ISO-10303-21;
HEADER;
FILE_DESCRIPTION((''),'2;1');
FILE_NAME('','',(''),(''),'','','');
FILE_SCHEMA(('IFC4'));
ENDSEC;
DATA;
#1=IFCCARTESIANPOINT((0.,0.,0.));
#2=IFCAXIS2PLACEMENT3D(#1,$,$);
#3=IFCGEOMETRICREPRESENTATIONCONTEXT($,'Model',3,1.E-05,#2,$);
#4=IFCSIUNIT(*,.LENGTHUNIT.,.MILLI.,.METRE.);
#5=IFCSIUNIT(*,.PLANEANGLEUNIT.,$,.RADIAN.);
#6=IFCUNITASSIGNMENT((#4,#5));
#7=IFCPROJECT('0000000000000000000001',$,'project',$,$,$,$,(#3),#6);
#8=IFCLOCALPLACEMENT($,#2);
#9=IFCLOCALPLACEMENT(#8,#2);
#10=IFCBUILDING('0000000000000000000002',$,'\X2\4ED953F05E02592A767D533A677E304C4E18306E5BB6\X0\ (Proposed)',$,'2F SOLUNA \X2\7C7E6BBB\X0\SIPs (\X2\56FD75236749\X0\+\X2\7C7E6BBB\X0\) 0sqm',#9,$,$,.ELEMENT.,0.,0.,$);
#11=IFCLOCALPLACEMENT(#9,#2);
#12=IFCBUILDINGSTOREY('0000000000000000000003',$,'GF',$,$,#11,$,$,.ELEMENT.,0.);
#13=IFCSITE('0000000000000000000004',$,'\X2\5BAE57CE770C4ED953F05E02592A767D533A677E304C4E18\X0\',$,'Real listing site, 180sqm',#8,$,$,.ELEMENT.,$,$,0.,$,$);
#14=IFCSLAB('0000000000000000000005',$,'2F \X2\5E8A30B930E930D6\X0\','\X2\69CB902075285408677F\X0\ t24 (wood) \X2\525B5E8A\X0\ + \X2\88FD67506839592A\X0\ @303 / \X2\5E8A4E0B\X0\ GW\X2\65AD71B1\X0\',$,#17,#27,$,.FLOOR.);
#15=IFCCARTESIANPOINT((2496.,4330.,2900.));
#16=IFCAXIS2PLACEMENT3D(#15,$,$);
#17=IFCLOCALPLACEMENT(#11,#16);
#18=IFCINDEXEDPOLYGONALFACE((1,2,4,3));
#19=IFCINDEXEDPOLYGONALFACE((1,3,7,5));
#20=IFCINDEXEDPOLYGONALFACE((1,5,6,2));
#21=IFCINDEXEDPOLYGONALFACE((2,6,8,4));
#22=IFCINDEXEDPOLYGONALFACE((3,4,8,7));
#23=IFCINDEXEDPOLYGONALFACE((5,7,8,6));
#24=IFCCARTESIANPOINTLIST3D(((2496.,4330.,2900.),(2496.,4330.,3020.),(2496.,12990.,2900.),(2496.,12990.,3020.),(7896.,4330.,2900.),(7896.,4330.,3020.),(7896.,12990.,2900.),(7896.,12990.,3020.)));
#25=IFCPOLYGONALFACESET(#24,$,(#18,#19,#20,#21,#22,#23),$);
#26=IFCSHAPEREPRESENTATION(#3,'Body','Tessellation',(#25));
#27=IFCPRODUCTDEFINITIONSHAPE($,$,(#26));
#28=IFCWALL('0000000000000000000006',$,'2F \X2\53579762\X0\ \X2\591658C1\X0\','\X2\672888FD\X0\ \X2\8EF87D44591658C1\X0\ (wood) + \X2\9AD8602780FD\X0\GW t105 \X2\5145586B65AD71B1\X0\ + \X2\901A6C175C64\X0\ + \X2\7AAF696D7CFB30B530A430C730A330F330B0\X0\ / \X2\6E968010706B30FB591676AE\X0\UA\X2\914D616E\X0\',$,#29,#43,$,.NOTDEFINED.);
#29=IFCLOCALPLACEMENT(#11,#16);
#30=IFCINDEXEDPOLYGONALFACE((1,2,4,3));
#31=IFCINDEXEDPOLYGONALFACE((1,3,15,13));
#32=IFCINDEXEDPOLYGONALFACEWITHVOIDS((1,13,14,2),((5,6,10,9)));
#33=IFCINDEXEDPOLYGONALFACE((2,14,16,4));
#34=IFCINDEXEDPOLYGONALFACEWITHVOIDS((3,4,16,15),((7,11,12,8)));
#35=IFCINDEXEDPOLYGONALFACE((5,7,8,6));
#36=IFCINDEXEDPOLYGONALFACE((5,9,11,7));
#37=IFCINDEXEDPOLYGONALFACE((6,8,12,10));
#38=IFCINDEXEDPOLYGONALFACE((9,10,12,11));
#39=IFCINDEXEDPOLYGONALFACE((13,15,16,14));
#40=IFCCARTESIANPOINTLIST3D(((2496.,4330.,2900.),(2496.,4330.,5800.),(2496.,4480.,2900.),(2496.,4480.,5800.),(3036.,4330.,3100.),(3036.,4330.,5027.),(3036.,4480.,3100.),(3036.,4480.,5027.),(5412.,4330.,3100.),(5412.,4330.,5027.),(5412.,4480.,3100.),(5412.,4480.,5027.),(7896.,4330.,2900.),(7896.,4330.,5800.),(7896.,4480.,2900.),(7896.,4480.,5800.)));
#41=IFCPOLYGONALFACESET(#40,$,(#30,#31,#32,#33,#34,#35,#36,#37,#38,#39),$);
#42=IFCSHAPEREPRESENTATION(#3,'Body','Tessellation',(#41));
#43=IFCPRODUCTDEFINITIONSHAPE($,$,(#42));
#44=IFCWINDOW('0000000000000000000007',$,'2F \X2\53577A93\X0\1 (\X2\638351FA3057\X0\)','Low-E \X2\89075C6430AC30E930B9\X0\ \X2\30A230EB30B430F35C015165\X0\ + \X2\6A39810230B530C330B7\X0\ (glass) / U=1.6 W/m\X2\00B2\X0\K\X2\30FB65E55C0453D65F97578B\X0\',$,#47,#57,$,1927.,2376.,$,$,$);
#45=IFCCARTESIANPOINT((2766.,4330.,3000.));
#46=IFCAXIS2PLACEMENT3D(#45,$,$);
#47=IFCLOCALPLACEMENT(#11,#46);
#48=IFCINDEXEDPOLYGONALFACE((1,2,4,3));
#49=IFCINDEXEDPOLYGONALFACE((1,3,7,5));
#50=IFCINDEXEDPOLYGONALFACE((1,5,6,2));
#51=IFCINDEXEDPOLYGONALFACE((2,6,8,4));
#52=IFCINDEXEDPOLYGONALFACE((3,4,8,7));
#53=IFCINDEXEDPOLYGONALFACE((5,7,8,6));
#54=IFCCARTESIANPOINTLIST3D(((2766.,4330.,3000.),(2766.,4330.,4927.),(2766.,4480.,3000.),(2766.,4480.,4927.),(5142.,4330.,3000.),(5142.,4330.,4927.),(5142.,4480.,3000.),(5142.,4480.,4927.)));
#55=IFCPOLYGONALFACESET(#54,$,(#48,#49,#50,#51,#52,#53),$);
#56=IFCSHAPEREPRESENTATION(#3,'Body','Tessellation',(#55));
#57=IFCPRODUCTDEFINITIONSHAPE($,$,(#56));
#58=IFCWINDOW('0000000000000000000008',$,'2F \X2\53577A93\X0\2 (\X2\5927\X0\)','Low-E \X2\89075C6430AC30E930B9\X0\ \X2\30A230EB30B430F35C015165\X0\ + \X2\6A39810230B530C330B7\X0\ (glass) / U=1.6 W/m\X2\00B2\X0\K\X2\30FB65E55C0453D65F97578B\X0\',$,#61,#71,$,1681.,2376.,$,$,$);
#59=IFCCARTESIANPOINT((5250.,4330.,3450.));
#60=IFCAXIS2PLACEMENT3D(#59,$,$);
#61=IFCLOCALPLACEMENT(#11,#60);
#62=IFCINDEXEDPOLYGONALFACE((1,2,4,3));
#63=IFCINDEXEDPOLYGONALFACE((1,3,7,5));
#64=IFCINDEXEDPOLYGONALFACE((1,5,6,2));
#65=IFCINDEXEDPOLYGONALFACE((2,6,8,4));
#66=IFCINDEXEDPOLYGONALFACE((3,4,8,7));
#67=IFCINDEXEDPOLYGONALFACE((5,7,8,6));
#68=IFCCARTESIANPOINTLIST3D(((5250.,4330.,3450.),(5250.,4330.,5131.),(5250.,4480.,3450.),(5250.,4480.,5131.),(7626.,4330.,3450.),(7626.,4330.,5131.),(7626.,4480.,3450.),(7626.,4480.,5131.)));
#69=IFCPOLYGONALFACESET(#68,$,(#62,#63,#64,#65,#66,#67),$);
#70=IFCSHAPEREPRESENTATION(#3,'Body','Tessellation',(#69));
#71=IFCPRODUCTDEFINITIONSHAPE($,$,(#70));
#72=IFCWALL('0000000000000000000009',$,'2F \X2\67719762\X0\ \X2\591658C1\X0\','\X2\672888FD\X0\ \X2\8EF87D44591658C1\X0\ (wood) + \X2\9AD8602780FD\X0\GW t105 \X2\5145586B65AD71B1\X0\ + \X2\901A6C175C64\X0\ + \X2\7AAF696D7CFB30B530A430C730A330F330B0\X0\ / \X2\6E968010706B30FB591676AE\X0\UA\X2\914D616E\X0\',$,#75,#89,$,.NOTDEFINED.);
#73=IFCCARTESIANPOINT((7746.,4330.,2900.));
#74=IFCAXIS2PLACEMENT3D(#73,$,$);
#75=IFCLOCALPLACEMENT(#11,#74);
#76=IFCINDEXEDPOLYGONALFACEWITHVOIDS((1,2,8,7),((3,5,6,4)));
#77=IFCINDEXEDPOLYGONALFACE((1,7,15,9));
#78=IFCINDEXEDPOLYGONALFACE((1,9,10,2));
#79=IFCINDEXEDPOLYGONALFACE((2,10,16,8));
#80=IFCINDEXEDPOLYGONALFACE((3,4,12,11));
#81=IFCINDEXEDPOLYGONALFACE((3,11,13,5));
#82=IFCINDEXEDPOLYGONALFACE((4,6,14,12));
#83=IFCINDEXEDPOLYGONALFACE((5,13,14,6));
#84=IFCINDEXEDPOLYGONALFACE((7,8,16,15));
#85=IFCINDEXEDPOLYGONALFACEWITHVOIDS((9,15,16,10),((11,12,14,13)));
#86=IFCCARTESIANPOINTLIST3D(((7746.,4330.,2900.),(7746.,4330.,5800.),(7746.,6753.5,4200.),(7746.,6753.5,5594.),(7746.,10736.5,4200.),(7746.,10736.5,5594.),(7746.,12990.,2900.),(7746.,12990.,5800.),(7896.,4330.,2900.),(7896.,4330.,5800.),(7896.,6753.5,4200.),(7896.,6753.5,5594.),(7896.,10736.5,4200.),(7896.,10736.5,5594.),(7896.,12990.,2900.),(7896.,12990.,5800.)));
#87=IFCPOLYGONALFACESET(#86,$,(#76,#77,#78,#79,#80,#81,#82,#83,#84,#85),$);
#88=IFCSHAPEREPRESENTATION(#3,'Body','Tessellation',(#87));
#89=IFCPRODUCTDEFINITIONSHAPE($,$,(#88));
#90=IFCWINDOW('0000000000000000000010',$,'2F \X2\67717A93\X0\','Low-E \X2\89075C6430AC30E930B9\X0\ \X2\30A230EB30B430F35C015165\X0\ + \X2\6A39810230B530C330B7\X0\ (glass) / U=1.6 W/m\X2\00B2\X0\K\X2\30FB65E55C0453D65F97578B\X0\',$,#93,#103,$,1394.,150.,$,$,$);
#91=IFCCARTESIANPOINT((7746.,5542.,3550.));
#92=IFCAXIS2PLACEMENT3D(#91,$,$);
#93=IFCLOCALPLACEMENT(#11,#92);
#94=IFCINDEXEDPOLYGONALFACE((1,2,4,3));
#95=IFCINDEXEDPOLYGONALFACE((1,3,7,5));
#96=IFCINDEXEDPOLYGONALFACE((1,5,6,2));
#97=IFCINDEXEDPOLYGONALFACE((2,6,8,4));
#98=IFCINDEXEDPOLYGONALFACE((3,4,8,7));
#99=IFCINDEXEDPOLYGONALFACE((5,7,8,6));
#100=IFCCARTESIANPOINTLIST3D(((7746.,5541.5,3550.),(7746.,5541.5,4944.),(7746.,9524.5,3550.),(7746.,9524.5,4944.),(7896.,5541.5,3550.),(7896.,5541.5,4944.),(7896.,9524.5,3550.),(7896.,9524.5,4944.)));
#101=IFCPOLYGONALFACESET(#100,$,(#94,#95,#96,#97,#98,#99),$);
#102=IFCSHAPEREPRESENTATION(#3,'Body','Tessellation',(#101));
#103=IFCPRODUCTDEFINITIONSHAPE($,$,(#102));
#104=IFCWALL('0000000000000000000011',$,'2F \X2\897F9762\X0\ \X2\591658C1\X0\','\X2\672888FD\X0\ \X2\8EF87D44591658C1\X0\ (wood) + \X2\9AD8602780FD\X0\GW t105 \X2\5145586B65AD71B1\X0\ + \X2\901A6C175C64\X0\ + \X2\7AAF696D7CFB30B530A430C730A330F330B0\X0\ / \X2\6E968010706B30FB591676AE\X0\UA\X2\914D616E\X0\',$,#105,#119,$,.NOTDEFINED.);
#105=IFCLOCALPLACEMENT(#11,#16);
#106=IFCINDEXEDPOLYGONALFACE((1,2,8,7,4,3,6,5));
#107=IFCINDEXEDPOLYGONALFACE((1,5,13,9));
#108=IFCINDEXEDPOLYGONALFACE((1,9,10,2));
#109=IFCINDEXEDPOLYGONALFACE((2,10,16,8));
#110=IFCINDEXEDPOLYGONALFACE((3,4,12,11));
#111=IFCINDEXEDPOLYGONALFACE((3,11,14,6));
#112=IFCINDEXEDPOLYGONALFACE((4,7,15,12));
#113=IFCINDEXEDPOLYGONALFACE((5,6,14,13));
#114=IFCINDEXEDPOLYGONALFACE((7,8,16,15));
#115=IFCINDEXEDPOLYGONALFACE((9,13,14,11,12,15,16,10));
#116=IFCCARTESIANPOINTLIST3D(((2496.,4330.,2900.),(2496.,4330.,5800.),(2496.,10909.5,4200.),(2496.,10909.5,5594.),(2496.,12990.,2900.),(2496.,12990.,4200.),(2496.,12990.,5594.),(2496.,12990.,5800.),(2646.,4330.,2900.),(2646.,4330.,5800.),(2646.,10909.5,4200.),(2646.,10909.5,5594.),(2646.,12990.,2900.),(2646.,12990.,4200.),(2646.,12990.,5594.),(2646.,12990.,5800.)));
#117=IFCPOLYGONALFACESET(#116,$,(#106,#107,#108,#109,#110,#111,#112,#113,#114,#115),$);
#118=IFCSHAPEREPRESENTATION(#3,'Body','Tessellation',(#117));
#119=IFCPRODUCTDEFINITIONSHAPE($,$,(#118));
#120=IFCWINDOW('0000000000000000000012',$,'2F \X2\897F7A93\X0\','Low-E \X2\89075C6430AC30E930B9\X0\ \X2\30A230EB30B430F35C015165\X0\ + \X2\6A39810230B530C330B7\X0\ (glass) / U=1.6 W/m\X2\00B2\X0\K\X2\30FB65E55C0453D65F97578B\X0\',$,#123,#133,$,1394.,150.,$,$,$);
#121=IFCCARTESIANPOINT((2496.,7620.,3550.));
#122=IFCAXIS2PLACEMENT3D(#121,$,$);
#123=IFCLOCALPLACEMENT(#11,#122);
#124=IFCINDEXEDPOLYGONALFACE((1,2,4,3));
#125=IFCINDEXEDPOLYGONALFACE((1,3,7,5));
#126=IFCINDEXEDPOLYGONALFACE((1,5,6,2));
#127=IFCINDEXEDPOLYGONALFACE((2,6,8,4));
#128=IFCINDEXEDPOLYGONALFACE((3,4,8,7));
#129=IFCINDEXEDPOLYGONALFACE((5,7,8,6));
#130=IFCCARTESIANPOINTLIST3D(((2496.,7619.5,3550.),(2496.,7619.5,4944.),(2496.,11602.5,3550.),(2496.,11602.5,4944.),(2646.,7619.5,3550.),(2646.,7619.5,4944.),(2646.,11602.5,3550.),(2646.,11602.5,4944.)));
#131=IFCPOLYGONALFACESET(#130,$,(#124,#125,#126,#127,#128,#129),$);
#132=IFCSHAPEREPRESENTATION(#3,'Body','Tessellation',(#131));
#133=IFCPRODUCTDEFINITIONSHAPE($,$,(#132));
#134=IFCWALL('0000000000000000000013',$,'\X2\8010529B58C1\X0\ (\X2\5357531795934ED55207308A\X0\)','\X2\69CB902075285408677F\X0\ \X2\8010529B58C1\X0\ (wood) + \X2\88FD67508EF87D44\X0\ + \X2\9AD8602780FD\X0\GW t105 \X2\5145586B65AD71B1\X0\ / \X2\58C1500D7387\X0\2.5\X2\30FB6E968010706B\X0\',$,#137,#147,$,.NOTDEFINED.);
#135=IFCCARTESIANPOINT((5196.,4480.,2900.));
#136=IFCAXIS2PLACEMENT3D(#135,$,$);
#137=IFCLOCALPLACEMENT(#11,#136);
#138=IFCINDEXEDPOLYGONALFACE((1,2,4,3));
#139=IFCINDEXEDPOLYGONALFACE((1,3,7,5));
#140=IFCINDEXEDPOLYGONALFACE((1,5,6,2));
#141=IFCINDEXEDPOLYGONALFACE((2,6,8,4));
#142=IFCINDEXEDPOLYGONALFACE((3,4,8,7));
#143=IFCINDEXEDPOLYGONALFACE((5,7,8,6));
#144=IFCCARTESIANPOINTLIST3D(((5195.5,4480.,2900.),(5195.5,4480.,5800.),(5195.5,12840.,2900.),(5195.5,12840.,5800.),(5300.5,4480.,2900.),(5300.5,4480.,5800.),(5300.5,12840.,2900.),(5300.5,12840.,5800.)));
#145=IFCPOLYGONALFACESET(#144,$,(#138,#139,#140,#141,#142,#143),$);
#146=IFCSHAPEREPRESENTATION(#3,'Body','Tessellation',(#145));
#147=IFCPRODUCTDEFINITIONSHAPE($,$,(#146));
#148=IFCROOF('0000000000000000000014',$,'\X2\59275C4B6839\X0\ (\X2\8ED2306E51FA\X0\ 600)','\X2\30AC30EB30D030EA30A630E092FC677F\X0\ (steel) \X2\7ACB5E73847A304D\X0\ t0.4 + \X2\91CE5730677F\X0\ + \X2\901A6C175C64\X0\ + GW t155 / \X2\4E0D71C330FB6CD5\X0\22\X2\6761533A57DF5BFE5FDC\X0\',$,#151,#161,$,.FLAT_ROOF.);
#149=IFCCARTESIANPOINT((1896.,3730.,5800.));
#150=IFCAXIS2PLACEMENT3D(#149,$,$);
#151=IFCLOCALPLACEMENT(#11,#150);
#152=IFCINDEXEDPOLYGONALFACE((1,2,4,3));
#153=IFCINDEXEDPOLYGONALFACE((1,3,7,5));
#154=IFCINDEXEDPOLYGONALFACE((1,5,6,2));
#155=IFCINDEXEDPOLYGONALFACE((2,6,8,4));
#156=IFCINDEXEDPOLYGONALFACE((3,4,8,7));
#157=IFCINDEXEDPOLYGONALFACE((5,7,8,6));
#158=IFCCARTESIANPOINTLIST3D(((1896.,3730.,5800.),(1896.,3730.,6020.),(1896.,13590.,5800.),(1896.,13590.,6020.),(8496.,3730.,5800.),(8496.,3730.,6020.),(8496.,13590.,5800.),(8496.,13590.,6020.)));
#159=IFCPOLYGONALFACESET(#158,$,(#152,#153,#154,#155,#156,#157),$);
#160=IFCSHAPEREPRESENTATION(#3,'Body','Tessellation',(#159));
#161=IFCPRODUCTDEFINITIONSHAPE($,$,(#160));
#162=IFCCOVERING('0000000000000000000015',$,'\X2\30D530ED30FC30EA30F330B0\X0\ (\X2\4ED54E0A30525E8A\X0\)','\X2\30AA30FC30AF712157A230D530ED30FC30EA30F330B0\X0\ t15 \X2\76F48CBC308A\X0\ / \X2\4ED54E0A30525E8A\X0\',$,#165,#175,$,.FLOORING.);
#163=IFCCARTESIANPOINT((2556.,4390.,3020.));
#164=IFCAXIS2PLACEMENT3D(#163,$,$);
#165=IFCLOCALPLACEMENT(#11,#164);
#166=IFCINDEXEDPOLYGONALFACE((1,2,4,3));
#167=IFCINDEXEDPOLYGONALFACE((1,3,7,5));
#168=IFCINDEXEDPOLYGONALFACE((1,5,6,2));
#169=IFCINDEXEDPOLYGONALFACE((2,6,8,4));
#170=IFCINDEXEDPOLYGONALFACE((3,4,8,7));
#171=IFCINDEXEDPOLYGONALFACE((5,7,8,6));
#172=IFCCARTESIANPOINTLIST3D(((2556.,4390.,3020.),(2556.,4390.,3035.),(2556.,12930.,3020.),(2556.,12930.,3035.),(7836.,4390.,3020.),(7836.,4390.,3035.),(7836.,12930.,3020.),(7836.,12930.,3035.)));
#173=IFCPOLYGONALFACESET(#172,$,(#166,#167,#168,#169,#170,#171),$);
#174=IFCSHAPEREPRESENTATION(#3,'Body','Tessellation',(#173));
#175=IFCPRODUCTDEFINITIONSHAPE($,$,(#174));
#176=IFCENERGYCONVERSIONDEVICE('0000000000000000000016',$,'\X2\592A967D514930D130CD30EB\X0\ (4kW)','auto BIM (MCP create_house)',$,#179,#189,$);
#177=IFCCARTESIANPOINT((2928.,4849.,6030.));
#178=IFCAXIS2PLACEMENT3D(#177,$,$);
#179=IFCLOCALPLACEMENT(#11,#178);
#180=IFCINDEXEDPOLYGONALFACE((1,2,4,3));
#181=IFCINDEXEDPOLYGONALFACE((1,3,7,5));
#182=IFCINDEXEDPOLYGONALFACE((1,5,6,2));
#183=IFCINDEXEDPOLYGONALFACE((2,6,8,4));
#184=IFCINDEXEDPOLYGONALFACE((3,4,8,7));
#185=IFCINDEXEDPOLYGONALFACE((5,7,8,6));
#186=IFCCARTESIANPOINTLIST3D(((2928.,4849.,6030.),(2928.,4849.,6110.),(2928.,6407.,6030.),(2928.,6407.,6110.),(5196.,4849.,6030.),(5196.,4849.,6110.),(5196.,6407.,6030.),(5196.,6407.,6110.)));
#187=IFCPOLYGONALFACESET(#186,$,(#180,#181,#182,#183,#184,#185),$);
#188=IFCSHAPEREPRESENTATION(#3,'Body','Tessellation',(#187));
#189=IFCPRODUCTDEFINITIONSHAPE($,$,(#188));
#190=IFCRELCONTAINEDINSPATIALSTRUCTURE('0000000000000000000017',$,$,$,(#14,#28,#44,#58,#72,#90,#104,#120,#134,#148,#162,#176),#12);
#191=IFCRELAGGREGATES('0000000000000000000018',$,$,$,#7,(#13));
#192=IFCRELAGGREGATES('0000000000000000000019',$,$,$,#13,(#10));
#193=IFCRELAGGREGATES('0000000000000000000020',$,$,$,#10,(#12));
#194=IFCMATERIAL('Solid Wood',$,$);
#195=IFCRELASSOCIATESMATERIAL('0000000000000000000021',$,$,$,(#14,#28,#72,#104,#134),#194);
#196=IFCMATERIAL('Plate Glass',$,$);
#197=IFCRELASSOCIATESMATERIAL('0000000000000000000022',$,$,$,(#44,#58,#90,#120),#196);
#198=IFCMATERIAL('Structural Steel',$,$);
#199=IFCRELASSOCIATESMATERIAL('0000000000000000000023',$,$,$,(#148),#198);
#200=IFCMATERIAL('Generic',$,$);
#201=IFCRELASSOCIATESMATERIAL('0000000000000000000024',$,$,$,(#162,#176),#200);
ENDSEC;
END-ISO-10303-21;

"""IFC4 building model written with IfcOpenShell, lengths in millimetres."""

from ifc_helpers import new_model, si_unit, frame, frame_2d, origin, place, context, project, spatial, rectangle, extrude, material, element, fill, save


model = new_model("IFC4")

# Units and contexts
model_context = context("Model", 3, precision=1e-05, world=origin())
ifc_project = project(units=[si_unit("LENGTHUNIT", "METRE", prefix="MILLI"), si_unit("PLANEANGLEUNIT", "RADIAN")], contexts=[model_context])

# Site, building, storey
site_placement = place(None, origin())
site = spatial("IfcSite", under=ifc_project, at=site_placement, Name="宮城県仙台市太白区松が丘", ObjectType="Real listing site, 180sqm", CompositionType="ELEMENT", RefElevation=0.0)
building_placement = place(site_placement, origin())
building = spatial("IfcBuilding", under=site, at=building_placement, Name="仙台市太白区松が丘の家 (Proposed)", ObjectType="2F SOLUNA 籾殻SIPs (国産杉+籾殻) 0sqm", CompositionType="ELEMENT", ElevationOfRefHeight=0.0, ElevationOfTerrain=0.0)
storey_placement = place(building_placement, origin())
storey = spatial("IfcBuildingStorey", under=building, at=storey_placement, Name="GF", CompositionType="ELEMENT", Elevation=0.0)

# Slab
ifc_material_1 = material(Name="Solid Wood")
slab_placement = place(storey_placement, frame((2496.0, 4330.0, 2900.0)))
element("IfcSlab", 1, at=slab_placement, inside=storey, material=ifc_material_1, Name="2F 床スラブ", Description="構造用合板 t24 (wood) 剛床 + 製材根太 @303 / 床下 GW断熱", PredefinedType="FLOOR", context=model_context, shape_type="SweptSolid", body=[
    extrude(rectangle(XDim=5400.0, YDim=8660.0, at=frame_2d((2700.0, 4330.0))), frame((2496.0, 4330.0, 2900.0)), (0.0, 0.0, 1.0), 120.0),
])

# Wall, openings, windows
wall_1_placement = place(storey_placement, frame((2496.0, 4330.0, 2900.0)))
wall_1 = element("IfcWall", 2, at=wall_1_placement, inside=storey, material=ifc_material_1, Name="2F 南面 外壁", Description="木製 軸組外壁 (wood) + 高性能GW t105 充填断熱 + 通気層 + 窯業系サイディング / 準耐火・外皮UA配慮", PredefinedType="NOTDEFINED", context=model_context, shape_type="SweptSolid", body=[
    extrude(rectangle(XDim=5400.0, YDim=150.0, at=frame_2d((2700.0, 75.0))), frame((2496.0, 4330.0, 2900.0)), (0.0, 0.0, 1.0), 2900.0),
])
opening_1_placement = place(storey_placement, frame((2766.0, 4330.0, 3000.0)))
opening_1 = element("IfcOpeningElement", 3, at=opening_1_placement, cuts=wall_1, PredefinedType="NOTDEFINED", context=model_context, shape_type="SweptSolid", body=[
    extrude(rectangle(XDim=2376.0, YDim=150.0, at=frame_2d((1188.0, 75.0))), frame((2766.0, 4330.0, 3000.0)), (0.0, 0.0, 1.0), 1927.0),
])
opening_2_placement = place(storey_placement, frame((5250.0, 4330.0, 3450.0)))
opening_2 = element("IfcOpeningElement", 4, at=opening_2_placement, cuts=wall_1, PredefinedType="NOTDEFINED", context=model_context, shape_type="SweptSolid", body=[
    extrude(rectangle(XDim=2376.0, YDim=150.0, at=frame_2d((1188.0, 75.0))), frame((5250.0, 4330.0, 3450.0)), (0.0, 0.0, 1.0), 1681.0),
])
ifc_material_2 = material(Name="Plate Glass")
window_1_placement = place(storey_placement, frame((2766.0, 4330.0, 3000.0)))
window_1 = element("IfcWindow", 5, at=window_1_placement, inside=storey, material=ifc_material_2, Name="2F 南窓1 (掃出し)", Description="Low-E 複層ガラス アルゴン封入 + 樹脂サッシ (glass) / U=1.6 W/m²K・日射取得型", OverallHeight=1927.0, OverallWidth=2376.0, context=model_context, shape_type="SweptSolid", body=[
    extrude(rectangle(XDim=2376.0, YDim=150.0, at=frame_2d((1188.0, 75.0))), frame((2766.0, 4330.0, 3000.0)), (0.0, 0.0, 1.0), 1927.0),
])
fill(opening_1, window_1)
window_2_placement = place(storey_placement, frame((5250.0, 4330.0, 3450.0)))
window_2 = element("IfcWindow", 6, at=window_2_placement, inside=storey, material=ifc_material_2, Name="2F 南窓2 (大)", Description="Low-E 複層ガラス アルゴン封入 + 樹脂サッシ (glass) / U=1.6 W/m²K・日射取得型", OverallHeight=1681.0, OverallWidth=2376.0, context=model_context, shape_type="SweptSolid", body=[
    extrude(rectangle(XDim=2376.0, YDim=150.0, at=frame_2d((1188.0, 75.0))), frame((5250.0, 4330.0, 3450.0)), (0.0, 0.0, 1.0), 1681.0),
])
fill(opening_2, window_2)

# Walls, openings, windows
wall_2_placement = place(storey_placement, frame((7746.0, 4330.0, 2900.0)))
wall_2 = element("IfcWall", 7, at=wall_2_placement, inside=storey, material=ifc_material_1, Name="2F 東面 外壁", Description="木製 軸組外壁 (wood) + 高性能GW t105 充填断熱 + 通気層 + 窯業系サイディング / 準耐火・外皮UA配慮", PredefinedType="NOTDEFINED", context=model_context, shape_type="SweptSolid", body=[
    extrude(rectangle(XDim=150.0, YDim=8660.0, at=frame_2d((75.0, 4330.0))), frame((7746.0, 4330.0, 2900.0)), (0.0, 0.0, 1.0), 2900.0),
])
opening_3_placement = place(storey_placement, frame((7746.0, 5542.0, 3550.0)))
opening_3 = element("IfcOpeningElement", 8, at=opening_3_placement, cuts=wall_2, PredefinedType="NOTDEFINED", context=model_context, shape_type="SweptSolid", body=[
    extrude(rectangle(XDim=150.0, YDim=3983.0, at=frame_2d((75.0, 1991.0))), frame((7746.0, 5542.0, 3550.0)), (0.0, 0.0, 1.0), 1394.0),
])
window_3_placement = place(storey_placement, frame((7746.0, 5542.0, 3550.0)))
window_3 = element("IfcWindow", 9, at=window_3_placement, inside=storey, material=ifc_material_2, Name="2F 東窓", Description="Low-E 複層ガラス アルゴン封入 + 樹脂サッシ (glass) / U=1.6 W/m²K・日射取得型", OverallHeight=1394.0, OverallWidth=150.0, context=model_context, shape_type="SweptSolid", body=[
    extrude(rectangle(XDim=150.0, YDim=3983.0, at=frame_2d((75.0, 1991.0))), frame((7746.0, 5542.0, 3550.0)), (0.0, 0.0, 1.0), 1394.0),
])
fill(opening_3, window_3)
wall_3_placement = place(storey_placement, frame((2496.0, 4330.0, 2900.0)))
wall_3 = element("IfcWall", 10, at=wall_3_placement, inside=storey, material=ifc_material_1, Name="2F 西面 外壁", Description="木製 軸組外壁 (wood) + 高性能GW t105 充填断熱 + 通気層 + 窯業系サイディング / 準耐火・外皮UA配慮", PredefinedType="NOTDEFINED", context=model_context, shape_type="SweptSolid", body=[
    extrude(rectangle(XDim=150.0, YDim=8660.0, at=frame_2d((75.0, 4330.0))), frame((2496.0, 4330.0, 2900.0)), (0.0, 0.0, 1.0), 2900.0),
])
opening_4_placement = place(storey_placement, frame((2496.0, 7620.0, 3550.0)))
opening_4 = element("IfcOpeningElement", 11, at=opening_4_placement, cuts=wall_3, PredefinedType="NOTDEFINED", context=model_context, shape_type="SweptSolid", body=[
    extrude(rectangle(XDim=150.0, YDim=3983.0, at=frame_2d((75.0, 1991.0))), frame((2496.0, 7620.0, 3550.0)), (0.0, 0.0, 1.0), 1394.0),
])
window_4_placement = place(storey_placement, frame((2496.0, 7620.0, 3550.0)))
window_4 = element("IfcWindow", 12, at=window_4_placement, inside=storey, material=ifc_material_2, Name="2F 西窓", Description="Low-E 複層ガラス アルゴン封入 + 樹脂サッシ (glass) / U=1.6 W/m²K・日射取得型", OverallHeight=1394.0, OverallWidth=150.0, context=model_context, shape_type="SweptSolid", body=[
    extrude(rectangle(XDim=150.0, YDim=3983.0, at=frame_2d((75.0, 1991.0))), frame((2496.0, 7620.0, 3550.0)), (0.0, 0.0, 1.0), 1394.0),
])
fill(opening_4, window_4)

# Wall
wall_4_placement = place(storey_placement, frame((5196.0, 4480.0, 2900.0)))
element("IfcWall", 13, at=wall_4_placement, inside=storey, material=ifc_material_1, Name="耐力壁 (南北間仕切り)", Description="構造用合板 耐力壁 (wood) + 製材軸組 + 高性能GW t105 充填断熱 / 壁倍率2.5・準耐火", PredefinedType="NOTDEFINED", context=model_context, shape_type="SweptSolid", body=[
    extrude(rectangle(XDim=105.0, YDim=8360.0, at=frame_2d((52.0, 4180.0))), frame((5196.0, 4480.0, 2900.0)), (0.0, 0.0, 1.0), 2900.0),
])

# Roof
ifc_material_3 = material(Name="Structural Steel")
roof_placement = place(storey_placement, frame((1896.0, 3730.0, 5800.0)))
element("IfcRoof", 14, at=roof_placement, inside=storey, material=ifc_material_3, Name="大屋根 (軒の出 600)", Description="ガルバリウム鋼板 (steel) 立平葺き t0.4 + 野地板 + 通気層 + GW t155 / 不燃・法22条区域対応", PredefinedType="FLAT_ROOF", context=model_context, shape_type="SweptSolid", body=[
    extrude(rectangle(XDim=6600.0, YDim=9860.0, at=frame_2d((3300.0, 4930.0))), frame((1896.0, 3730.0, 5800.0)), (0.0, 0.0, 1.0), 220.0),
])

# Covering
ifc_material_4 = material(Name="Generic")
covering_placement = place(storey_placement, frame((2556.0, 4390.0, 3020.0)))
element("IfcCovering", 15, at=covering_placement, inside=storey, material=ifc_material_4, Name="フローリング (仕上げ床)", Description="オーク無垢フローリング t15 直貼り / 仕上げ床", PredefinedType="FLOORING", context=model_context, shape_type="SweptSolid", body=[
    extrude(rectangle(XDim=5280.0, YDim=8540.0, at=frame_2d((2640.0, 4270.0))), frame((2556.0, 4390.0, 3020.0)), (0.0, 0.0, 1.0), 15.0),
])

# Energy conversion device
energy_conversion_device_placement = place(storey_placement, frame((2928.0, 4849.0, 6030.0)))
element("IfcEnergyConversionDevice", 16, at=energy_conversion_device_placement, inside=storey, material=ifc_material_4, Name="太陽光パネル (4kW)", Description="auto BIM (MCP create_house)", context=model_context, shape_type="SweptSolid", body=[
    extrude(rectangle(XDim=2268.0, YDim=1558.0, at=frame_2d((1134.0, 779.0))), frame((2928.0, 4849.0, 6030.0)), (0.0, 0.0, 1.0), 80.0),
])

save(model, "model.ifc")
